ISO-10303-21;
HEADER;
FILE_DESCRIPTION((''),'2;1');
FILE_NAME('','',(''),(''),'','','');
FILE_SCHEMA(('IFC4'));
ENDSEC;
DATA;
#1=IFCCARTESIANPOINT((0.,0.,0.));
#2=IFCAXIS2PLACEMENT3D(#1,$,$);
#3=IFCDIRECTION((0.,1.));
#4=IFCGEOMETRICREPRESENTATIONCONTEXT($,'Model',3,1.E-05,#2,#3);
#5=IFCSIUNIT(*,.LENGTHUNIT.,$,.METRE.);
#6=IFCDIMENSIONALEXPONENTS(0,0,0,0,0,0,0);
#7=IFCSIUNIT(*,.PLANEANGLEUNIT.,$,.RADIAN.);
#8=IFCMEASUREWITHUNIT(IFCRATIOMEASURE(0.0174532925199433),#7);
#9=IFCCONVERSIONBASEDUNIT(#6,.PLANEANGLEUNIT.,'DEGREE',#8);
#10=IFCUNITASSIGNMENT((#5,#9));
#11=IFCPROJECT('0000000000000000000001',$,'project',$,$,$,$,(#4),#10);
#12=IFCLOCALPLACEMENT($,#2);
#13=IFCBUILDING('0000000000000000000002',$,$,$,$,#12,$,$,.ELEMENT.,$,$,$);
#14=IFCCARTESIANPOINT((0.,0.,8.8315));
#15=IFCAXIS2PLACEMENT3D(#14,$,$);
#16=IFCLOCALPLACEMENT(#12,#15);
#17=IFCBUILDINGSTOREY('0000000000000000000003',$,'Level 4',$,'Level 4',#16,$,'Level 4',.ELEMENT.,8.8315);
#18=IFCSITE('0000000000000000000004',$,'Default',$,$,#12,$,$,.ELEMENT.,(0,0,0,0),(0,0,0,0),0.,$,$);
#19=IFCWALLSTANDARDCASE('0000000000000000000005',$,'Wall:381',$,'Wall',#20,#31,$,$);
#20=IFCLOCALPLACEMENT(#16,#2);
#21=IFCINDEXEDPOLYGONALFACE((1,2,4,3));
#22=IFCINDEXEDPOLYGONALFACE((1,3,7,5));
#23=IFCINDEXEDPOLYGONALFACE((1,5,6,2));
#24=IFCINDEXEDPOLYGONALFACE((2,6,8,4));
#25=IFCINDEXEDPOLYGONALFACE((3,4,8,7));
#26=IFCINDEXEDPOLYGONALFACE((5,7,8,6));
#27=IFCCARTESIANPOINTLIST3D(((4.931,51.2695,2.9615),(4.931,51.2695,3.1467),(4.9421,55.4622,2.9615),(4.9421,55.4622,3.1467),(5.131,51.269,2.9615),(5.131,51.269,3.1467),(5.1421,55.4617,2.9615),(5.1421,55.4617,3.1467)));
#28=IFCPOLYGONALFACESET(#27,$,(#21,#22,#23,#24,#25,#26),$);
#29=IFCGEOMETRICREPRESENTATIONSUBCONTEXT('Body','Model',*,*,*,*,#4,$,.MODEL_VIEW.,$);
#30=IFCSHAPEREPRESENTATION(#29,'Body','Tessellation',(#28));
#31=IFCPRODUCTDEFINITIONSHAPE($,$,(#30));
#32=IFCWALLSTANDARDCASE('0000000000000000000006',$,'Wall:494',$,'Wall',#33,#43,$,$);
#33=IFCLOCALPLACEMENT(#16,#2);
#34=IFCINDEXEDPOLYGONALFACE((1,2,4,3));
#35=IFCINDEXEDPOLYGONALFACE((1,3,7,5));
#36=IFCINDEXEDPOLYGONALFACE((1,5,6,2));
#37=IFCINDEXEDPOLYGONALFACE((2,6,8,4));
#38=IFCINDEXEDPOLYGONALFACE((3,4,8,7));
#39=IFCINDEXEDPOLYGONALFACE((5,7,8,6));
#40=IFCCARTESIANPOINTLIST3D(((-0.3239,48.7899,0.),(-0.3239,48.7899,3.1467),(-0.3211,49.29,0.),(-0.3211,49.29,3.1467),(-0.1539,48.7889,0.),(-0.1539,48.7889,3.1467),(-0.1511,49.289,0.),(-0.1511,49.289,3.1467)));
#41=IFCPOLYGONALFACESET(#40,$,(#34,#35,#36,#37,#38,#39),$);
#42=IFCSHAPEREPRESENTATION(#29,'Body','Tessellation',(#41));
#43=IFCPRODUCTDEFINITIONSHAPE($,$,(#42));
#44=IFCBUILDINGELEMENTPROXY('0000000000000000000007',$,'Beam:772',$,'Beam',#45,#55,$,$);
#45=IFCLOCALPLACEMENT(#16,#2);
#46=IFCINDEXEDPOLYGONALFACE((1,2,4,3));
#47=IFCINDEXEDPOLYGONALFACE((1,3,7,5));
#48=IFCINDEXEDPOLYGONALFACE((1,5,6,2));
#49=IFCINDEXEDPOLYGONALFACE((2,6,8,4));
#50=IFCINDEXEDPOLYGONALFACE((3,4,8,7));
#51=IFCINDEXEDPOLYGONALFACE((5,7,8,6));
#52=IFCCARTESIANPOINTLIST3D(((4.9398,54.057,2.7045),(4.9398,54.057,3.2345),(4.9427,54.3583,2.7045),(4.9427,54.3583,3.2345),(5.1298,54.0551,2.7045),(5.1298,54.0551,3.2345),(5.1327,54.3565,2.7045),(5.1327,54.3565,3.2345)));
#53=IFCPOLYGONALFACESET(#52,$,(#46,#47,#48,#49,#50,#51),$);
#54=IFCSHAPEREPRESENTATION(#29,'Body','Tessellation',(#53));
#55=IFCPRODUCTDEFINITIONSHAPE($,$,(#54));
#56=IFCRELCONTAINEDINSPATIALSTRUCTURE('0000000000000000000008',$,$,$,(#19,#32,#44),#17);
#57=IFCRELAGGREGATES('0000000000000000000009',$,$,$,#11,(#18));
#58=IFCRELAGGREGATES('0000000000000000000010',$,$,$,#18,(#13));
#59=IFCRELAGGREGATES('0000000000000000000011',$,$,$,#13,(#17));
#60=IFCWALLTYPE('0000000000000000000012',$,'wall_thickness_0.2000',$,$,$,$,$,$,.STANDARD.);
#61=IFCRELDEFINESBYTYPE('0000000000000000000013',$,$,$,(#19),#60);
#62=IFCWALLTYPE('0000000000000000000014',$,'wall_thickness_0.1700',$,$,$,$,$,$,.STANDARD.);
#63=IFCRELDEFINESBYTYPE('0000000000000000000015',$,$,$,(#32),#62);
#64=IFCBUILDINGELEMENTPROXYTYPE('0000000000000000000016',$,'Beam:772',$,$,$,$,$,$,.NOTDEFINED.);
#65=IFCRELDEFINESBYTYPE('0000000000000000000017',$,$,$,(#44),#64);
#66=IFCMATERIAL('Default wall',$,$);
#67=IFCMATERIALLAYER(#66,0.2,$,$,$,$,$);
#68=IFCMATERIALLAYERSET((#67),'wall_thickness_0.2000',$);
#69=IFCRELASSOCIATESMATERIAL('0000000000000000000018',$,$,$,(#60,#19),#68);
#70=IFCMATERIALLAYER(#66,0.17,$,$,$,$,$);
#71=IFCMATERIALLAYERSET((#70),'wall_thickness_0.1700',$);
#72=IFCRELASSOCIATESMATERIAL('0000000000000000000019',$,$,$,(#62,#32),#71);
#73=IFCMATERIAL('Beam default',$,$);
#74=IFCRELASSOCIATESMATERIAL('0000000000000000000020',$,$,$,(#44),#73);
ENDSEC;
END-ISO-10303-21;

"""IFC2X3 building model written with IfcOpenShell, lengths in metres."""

from ifc_helpers import new_model, entity, si_unit, converted_unit, direction, frame, origin, place, context, subcontext, project, spatial, polyline, outline, extrude, source, transform, mapped, material, layer, layer_set, layer_usage, type_object, type_shapes, element, save


model = new_model("IFC2X3")

# Units and contexts
model_context = context("Model", 3, precision=1e-05, world=origin(), true_north=direction((0.0, 1.0)))
body_context = subcontext(model_context, "Body", "Model", "MODEL_VIEW")
ifc_project = project(units=[si_unit("LENGTHUNIT", "METRE"), converted_unit("PLANEANGLEUNIT", "DEGREE", entity("IfcRatioMeasure", 0.0174532925199433), si_unit("PLANEANGLEUNIT", "RADIAN"), dimensions=[0, 0, 0, 0, 0, 0, 0])], contexts=[model_context])

# Site, building, storey
placement_1 = place(None, origin())
site = spatial("IfcSite", under=ifc_project, at=placement_1, Name="Default", CompositionType="ELEMENT", RefLatitude=(0, 0, 0, 0), RefLongitude=(0, 0, 0, 0), RefElevation=0.0)
building = spatial("IfcBuilding", under=site, at=placement_1, CompositionType="ELEMENT")
storey_placement = place(placement_1, frame((0.0, 0.0, 8.8315)))
storey = spatial("IfcBuildingStorey", under=building, at=storey_placement, Name="Level 4", ObjectType="Level 4", LongName="Level 4", CompositionType="ELEMENT", Elevation=8.8315)

# Shared definitions
ifc_material_1 = material(Name="Default wall")

# Walls
ifc_layer_1 = layer(ifc_material_1, 0.2)
ifc_layer_set_1 = layer_set([ifc_layer_1], Name="wall_thickness_0.2000")
ifc_layer_usage_1 = layer_usage(ifc_layer_set_1, "AXIS2", "POSITIVE", -0.1)
wall_type_1 = type_object("IfcWallType", Name="wall_thickness_0.2000", PredefinedType="STANDARD", material=ifc_layer_set_1)
placement_2 = place(placement_1, frame((0.0, 0.0, 11.793)))
wall_1_placement = place(placement_2, frame((5.0421, 55.4619, 0.0), z_axis=(0.0, 0.0, 1.0), x_axis=(-0.002645, -0.999997, 0.0)))
element("IfcWallStandardCase", 1, at=wall_1_placement, inside=storey, type_object=wall_type_1, material=ifc_layer_usage_1, Name="Wall:381", ObjectType="Wall", context=body_context, shape_type="SweptSolid", body=[
    extrude(outline(polyline([(4.1927, -0.1), (4.1927, 0.1), (0.0, 0.1), (0.0, -0.1), (4.1927, -0.1)])), origin(), (0.0, 0.0, 1.0), 0.1852),
])
ifc_layer_2 = layer(ifc_material_1, 0.17)
ifc_layer_set_2 = layer_set([ifc_layer_2], Name="wall_thickness_0.1700")
ifc_layer_usage_2 = layer_usage(ifc_layer_set_2, "AXIS2", "POSITIVE", -0.085)
wall_type_2 = type_object("IfcWallType", Name="wall_thickness_0.1700", PredefinedType="STANDARD", material=ifc_layer_set_2)
wall_2_placement = place(storey_placement, frame((-0.2361, 49.2895, 0.0), z_axis=(0.0, 0.0, 1.0), x_axis=(-0.005553, -0.999985, 0.0)))
element("IfcWallStandardCase", 2, at=wall_2_placement, inside=storey, type_object=wall_type_2, material=ifc_layer_usage_2, Name="Wall:494", ObjectType="Wall", context=body_context, shape_type="SweptSolid", body=[
    extrude(outline(polyline([(0.5001, -0.085), (0.5001, 0.085), (0.0, 0.085), (0.0, -0.085), (0.5001, -0.085)])), origin(), (0.0, 0.0, 1.0), 3.1467),
])

# Building element proxy
ifc_material_2 = material(Name="Beam default")
building_element_proxy_type = type_object("IfcBuildingElementProxyType", Name="Beam:772", PredefinedType="NOTDEFINED")
shared_shape_1 = source(origin(), body_context, "Body", "SweptSolid", [
    extrude(outline(polyline([(0.3013, -0.095), (0.3013, 0.095), (0.0, 0.095), (0.0, -0.095), (0.3013, -0.095)])), origin(), (0.0, 0.0, 1.0), 0.53),
])
type_shapes(building_element_proxy_type, [shared_shape_1])
placement_3 = place(placement_1, frame((0.0, 0.0, 11.536)))
proxy_placement = place(placement_3, frame((5.0377, 54.3574, 0.0), z_axis=(0.0, 0.0, 1.0), x_axis=(-0.009667, -0.999953, 0.0)))
element("IfcBuildingElementProxy", 3, at=proxy_placement, inside=storey, type_object=building_element_proxy_type, material=ifc_material_2, Name="Beam:772", ObjectType="Beam", context=body_context, shape_type="MappedRepresentation", body=[
    mapped(shared_shape_1, transform((0.0, 0.0, 0.0), scale=1.0)),
])

save(model, "model.ifc")
